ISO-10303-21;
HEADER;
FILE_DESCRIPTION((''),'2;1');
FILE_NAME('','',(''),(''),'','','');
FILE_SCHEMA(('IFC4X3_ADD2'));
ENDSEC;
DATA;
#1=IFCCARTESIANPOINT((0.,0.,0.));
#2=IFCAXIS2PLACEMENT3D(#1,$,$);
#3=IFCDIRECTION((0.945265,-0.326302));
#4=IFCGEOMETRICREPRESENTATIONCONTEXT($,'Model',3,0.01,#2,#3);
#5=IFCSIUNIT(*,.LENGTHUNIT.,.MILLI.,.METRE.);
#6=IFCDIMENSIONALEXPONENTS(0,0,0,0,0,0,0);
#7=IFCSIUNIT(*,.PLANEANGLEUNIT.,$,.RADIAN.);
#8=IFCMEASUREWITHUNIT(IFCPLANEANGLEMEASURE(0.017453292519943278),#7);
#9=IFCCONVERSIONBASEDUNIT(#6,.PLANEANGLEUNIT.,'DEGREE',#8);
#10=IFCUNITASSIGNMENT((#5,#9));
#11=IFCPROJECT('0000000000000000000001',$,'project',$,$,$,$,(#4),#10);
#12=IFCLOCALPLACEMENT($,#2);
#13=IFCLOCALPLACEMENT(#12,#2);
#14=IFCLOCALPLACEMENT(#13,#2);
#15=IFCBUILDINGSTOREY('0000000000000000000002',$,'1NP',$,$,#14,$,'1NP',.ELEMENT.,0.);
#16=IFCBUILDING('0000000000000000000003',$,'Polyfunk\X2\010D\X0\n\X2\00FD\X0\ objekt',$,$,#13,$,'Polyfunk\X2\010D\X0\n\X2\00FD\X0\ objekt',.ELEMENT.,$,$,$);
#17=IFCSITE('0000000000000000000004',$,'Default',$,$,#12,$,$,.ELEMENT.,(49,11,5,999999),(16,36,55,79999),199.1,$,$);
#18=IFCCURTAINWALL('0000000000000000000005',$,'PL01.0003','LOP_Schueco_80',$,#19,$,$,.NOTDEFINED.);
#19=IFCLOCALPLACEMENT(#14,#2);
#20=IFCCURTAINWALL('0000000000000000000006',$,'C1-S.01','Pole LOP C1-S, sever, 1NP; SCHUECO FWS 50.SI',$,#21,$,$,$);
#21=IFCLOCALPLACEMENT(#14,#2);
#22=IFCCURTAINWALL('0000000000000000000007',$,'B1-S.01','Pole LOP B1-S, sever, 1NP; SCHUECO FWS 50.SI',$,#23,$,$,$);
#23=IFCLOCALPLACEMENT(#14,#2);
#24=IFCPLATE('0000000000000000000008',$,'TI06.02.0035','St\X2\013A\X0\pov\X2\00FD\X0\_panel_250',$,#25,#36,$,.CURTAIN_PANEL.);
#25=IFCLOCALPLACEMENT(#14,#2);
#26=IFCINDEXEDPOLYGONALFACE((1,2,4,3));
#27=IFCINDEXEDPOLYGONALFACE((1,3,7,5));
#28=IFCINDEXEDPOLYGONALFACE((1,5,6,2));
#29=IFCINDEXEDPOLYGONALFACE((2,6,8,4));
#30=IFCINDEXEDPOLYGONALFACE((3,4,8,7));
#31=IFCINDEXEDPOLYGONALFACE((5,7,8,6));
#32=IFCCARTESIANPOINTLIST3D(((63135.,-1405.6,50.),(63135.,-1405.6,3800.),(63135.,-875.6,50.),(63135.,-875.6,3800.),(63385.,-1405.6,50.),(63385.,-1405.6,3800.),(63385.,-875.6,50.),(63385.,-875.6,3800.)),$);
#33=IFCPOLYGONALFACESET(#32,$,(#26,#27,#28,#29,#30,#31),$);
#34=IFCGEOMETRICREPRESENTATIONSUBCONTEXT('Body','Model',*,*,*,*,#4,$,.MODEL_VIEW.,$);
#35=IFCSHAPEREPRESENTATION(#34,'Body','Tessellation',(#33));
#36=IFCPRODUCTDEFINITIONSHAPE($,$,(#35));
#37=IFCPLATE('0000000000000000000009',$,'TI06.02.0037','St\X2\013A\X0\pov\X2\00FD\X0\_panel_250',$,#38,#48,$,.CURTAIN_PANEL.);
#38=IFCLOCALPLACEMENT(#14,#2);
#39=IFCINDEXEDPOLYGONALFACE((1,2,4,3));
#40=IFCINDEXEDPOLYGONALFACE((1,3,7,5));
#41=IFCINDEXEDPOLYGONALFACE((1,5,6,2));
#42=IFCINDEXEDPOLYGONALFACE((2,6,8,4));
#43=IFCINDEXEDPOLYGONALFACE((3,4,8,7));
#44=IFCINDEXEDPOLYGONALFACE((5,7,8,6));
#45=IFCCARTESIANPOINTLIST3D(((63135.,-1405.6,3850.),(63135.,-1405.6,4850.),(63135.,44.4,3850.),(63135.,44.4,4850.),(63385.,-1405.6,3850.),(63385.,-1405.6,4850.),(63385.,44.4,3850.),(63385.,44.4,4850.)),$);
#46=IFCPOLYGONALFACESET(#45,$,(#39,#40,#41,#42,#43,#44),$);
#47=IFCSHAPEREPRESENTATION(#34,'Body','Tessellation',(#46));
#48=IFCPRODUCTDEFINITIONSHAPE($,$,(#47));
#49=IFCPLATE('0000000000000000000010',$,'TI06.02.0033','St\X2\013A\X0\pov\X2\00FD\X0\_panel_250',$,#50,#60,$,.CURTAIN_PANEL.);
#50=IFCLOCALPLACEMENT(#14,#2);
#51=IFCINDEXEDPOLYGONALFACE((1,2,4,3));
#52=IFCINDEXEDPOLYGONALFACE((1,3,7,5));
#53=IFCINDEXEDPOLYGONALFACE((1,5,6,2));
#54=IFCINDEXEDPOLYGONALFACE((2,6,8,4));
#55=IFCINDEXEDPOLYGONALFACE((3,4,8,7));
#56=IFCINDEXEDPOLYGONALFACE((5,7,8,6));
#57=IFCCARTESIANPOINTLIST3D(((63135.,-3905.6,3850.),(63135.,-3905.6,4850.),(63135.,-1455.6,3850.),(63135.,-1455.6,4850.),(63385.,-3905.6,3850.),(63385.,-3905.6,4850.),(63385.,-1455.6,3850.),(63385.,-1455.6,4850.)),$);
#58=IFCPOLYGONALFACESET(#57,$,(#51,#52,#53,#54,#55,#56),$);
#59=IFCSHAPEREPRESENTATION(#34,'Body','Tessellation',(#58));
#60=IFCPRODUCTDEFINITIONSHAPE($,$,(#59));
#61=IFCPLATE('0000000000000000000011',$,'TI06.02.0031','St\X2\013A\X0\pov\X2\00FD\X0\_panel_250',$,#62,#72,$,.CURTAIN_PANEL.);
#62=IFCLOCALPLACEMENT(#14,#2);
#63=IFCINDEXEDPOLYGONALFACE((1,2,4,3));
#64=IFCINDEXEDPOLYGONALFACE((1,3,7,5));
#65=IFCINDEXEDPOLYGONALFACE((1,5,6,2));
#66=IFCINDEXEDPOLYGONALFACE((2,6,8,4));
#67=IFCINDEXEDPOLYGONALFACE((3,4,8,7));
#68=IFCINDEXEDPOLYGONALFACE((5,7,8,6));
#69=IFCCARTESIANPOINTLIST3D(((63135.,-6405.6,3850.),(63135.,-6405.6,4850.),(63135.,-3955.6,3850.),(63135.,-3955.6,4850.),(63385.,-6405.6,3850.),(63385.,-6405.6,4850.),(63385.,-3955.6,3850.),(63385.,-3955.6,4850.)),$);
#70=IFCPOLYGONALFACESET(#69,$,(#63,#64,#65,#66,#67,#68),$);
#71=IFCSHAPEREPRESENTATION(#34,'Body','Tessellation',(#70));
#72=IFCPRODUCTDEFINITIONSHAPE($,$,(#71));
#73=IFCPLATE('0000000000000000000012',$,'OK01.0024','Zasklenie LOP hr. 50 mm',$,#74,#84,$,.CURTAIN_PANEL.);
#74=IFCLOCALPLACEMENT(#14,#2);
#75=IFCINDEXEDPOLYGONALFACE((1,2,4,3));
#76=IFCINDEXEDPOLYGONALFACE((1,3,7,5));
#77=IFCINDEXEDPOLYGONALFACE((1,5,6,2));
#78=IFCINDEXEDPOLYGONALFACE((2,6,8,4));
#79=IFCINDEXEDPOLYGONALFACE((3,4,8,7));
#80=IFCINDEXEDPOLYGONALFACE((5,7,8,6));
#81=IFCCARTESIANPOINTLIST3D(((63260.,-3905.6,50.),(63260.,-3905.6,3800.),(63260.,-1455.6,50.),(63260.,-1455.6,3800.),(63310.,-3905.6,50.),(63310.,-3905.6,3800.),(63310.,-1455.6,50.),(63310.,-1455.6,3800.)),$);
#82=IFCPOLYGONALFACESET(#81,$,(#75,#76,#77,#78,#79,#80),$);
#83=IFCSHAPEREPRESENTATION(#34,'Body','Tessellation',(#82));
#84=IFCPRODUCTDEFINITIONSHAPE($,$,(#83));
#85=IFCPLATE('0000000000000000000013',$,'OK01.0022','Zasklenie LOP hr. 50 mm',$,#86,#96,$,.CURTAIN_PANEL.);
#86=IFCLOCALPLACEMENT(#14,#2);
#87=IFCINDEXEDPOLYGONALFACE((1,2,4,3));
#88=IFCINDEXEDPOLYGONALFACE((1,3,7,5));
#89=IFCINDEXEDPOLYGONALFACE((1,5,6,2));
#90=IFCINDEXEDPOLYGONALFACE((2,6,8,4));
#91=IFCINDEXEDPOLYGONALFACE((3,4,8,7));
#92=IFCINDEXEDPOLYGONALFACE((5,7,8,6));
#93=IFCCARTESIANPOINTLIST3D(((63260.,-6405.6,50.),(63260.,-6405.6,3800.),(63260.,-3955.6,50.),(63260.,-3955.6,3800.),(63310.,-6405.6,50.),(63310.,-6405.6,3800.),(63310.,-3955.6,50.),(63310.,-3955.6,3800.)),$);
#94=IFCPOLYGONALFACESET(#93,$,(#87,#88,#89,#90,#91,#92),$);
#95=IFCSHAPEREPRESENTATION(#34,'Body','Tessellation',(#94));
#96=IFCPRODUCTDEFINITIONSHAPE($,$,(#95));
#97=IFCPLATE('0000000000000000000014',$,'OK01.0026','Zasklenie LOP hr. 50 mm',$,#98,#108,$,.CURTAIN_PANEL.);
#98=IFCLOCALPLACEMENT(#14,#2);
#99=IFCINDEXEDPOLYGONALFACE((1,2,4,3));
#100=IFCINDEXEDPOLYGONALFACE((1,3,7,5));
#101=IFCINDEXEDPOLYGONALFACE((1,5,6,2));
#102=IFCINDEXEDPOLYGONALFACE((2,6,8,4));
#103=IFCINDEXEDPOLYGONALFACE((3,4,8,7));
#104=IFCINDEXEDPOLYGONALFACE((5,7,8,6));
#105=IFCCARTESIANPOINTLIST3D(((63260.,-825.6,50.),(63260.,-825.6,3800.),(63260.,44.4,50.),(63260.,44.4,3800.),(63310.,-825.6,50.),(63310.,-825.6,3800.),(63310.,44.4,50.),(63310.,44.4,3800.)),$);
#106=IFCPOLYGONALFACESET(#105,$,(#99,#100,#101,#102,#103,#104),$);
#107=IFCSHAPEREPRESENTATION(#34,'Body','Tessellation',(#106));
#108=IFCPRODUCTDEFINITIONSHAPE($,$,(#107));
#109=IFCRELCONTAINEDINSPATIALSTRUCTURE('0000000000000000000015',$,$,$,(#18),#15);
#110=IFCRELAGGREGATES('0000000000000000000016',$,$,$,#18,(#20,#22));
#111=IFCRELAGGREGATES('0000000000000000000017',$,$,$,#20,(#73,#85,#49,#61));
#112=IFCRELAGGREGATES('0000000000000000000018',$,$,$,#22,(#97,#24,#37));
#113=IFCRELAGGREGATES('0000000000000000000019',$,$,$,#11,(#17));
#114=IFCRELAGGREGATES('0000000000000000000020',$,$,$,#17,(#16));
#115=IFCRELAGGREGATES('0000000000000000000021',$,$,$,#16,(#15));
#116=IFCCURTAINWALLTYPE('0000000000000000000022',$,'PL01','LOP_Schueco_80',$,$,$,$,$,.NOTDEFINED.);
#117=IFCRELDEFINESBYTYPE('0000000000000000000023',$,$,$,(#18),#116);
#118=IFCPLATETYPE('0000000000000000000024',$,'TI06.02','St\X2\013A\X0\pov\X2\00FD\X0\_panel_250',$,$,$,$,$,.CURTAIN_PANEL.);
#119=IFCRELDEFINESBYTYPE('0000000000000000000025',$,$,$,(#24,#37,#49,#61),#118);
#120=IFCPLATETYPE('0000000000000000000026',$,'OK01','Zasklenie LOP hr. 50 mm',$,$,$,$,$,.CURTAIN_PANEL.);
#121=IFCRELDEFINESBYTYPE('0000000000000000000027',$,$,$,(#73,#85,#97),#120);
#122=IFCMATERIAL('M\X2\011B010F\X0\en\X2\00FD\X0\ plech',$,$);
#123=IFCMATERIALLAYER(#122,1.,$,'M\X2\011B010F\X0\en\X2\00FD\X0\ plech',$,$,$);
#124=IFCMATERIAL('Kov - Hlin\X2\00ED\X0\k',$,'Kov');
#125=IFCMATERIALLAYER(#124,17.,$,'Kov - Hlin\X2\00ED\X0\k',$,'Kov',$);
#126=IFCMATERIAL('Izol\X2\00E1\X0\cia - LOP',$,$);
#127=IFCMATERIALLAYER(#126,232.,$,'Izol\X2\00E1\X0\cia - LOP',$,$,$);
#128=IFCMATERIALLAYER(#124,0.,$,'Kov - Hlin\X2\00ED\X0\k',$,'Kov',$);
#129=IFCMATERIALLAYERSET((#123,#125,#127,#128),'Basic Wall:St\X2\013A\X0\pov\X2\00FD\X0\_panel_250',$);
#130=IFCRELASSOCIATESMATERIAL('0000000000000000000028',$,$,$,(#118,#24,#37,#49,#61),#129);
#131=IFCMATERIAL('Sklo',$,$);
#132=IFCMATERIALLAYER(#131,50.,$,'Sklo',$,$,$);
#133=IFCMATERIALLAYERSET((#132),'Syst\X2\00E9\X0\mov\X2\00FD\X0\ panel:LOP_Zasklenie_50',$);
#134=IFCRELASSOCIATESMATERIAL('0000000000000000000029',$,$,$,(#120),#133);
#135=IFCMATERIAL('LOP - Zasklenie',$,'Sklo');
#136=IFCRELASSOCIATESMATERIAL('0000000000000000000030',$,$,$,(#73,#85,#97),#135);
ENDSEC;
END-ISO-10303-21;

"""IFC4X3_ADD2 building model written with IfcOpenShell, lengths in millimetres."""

from ifc_helpers import new_model, entity, si_unit, converted_unit, direction, frame, frame_2d, origin, place, context, subcontext, project, spatial, rectangle, extrude, source, transform, mapped, material, layer, layer_set, layer_usage, type_object, type_shapes, element, aggregate, save


model = new_model("IFC4X3_ADD2")

# Units and contexts
model_context = context("Model", 3, precision=0.01, world=origin(), true_north=direction((0.945265, -0.326302)))
body_context = subcontext(model_context, "Body", "Model", "MODEL_VIEW")
ifc_project = project(units=[si_unit("LENGTHUNIT", "METRE", prefix="MILLI"), converted_unit("PLANEANGLEUNIT", "DEGREE", entity("IfcPlaneAngleMeasure", 0.017453292519943278), si_unit("PLANEANGLEUNIT", "RADIAN"), dimensions=[0, 0, 0, 0, 0, 0, 0])], contexts=[model_context])

# Site, building, storey
site_placement = place(None, origin())
site = spatial("IfcSite", under=ifc_project, at=site_placement, Name="Default", CompositionType="ELEMENT", RefLatitude=(49, 11, 5, 999999), RefLongitude=(16, 36, 55, 79999), RefElevation=199.1)
building_placement = place(site_placement, origin())
building = spatial("IfcBuilding", under=site, at=building_placement, Name="Polyfunkčný objekt", LongName="Polyfunkčný objekt", CompositionType="ELEMENT")
storey_placement = place(building_placement, origin())
storey = spatial("IfcBuildingStorey", under=building, at=storey_placement, Name="1NP", LongName="1NP", CompositionType="ELEMENT", Elevation=0.0)

# Curtain walls, plates
curtain_wall_type = type_object("IfcCurtainWallType", Name="PL01", Description="LOP_Schueco_80", PredefinedType="NOTDEFINED")
curtain_wall_1_placement = place(storey_placement, origin())
curtain_wall_1 = element("IfcCurtainWall", 1, at=curtain_wall_1_placement, inside=storey, type_object=curtain_wall_type, Name="PL01.0003", Description="LOP_Schueco_80", PredefinedType="NOTDEFINED")
curtain_wall_2 = element("IfcCurtainWall", 2, Name="C1-S.01", Description="Pole LOP C1-S, sever, 1NP; SCHUECO FWS 50.SI")
curtain_wall_3 = element("IfcCurtainWall", 3, Name="B1-S.01", Description="Pole LOP B1-S, sever, 1NP; SCHUECO FWS 50.SI")
aggregate(curtain_wall_1, [curtain_wall_2, curtain_wall_3])
ifc_material_1 = material(Name="Měďený plech")
ifc_layer_1 = layer(ifc_material_1, 1.0, Name="Měďený plech")
ifc_material_2 = material(Name="Kov - Hliník", Category="Kov")
ifc_layer_2 = layer(ifc_material_2, 17.0, Name="Kov - Hliník", Category="Kov")
ifc_material_3 = material(Name="Izolácia - LOP")
ifc_layer_3 = layer(ifc_material_3, 232.0, Name="Izolácia - LOP")
ifc_layer_4 = layer(ifc_material_2, 0.0, Name="Kov - Hliník", Category="Kov")
ifc_layer_set_1 = layer_set([ifc_layer_1, ifc_layer_2, ifc_layer_3, ifc_layer_4], Name="Basic Wall:Stĺpový_panel_250")
ifc_layer_usage_1 = layer_usage(ifc_layer_set_1, "AXIS2", "NEGATIVE", 125.0)
plate_type_1 = type_object("IfcPlateType", Name="TI06.02", Description="Stĺpový_panel_250", PredefinedType="CURTAIN_PANEL", material=ifc_layer_set_1)
plate_1_placement = place(storey_placement, frame((63260.0, -875.6, 50.0), z_axis=(0.0, 0.0, 1.0), x_axis=(0.0, -1.0, 0.0)))
plate_1 = element("IfcPlate", 4, at=plate_1_placement, type_object=plate_type_1, material=ifc_layer_usage_1, Name="TI06.02.0035", Description="Stĺpový_panel_250", PredefinedType="CURTAIN_PANEL", context=body_context, shape_type="SweptSolid", body=[
    extrude(rectangle(XDim=250.0, YDim=530.0, at=frame_2d((0.0, 0.0), x_axis=(1.0, 0.0))), frame((265.0, 0.0, 0.0), z_axis=(0.0, 0.0, 1.0), x_axis=(0.0, 1.0, 0.0)), (0.0, 0.0, 1.0), 3750.0),
])
ifc_layer_usage_2 = layer_usage(ifc_layer_set_1, "AXIS2", "NEGATIVE", 125.0)
plate_2_placement = place(storey_placement, frame((63260.0, 44.4, 3850.0), z_axis=(0.0, 0.0, 1.0), x_axis=(0.0, -1.0, 0.0)))
plate_2 = element("IfcPlate", 5, at=plate_2_placement, type_object=plate_type_1, material=ifc_layer_usage_2, Name="TI06.02.0037", Description="Stĺpový_panel_250", PredefinedType="CURTAIN_PANEL", context=body_context, shape_type="SweptSolid", body=[
    extrude(rectangle(XDim=250.0, YDim=1450.0, at=frame_2d((0.0, 0.0), x_axis=(1.0, 0.0))), frame((725.0, 0.0, 0.0), z_axis=(0.0, 0.0, 1.0), x_axis=(0.0, 1.0, 0.0)), (0.0, 0.0, 1.0), 1000.0),
])
ifc_layer_usage_3 = layer_usage(ifc_layer_set_1, "AXIS2", "NEGATIVE", 125.0)
plate_3_placement = place(storey_placement, frame((63260.0, -1455.6, 3850.0), z_axis=(0.0, 0.0, 1.0), x_axis=(0.0, -1.0, 0.0)))
plate_3 = element("IfcPlate", 6, at=plate_3_placement, type_object=plate_type_1, material=ifc_layer_usage_3, Name="TI06.02.0033", Description="Stĺpový_panel_250", PredefinedType="CURTAIN_PANEL", context=body_context, shape_type="SweptSolid", body=[
    extrude(rectangle(XDim=250.0, YDim=2450.0, at=frame_2d((0.0, 0.0), x_axis=(1.0, 0.0))), frame((1225.0, 0.0, 0.0), z_axis=(0.0, 0.0, 1.0), x_axis=(0.0, 1.0, 0.0)), (0.0, 0.0, 1.0), 1000.0),
])
ifc_layer_usage_4 = layer_usage(ifc_layer_set_1, "AXIS2", "NEGATIVE", 125.0)
plate_4_placement = place(storey_placement, frame((63260.0, -3955.6, 3850.0), z_axis=(0.0, 0.0, 1.0), x_axis=(0.0, -1.0, 0.0)))
plate_4 = element("IfcPlate", 7, at=plate_4_placement, type_object=plate_type_1, material=ifc_layer_usage_4, Name="TI06.02.0031", Description="Stĺpový_panel_250", PredefinedType="CURTAIN_PANEL", context=body_context, shape_type="SweptSolid", body=[
    extrude(rectangle(XDim=250.0, YDim=2450.0, at=frame_2d((0.0, 0.0), x_axis=(1.0, 0.0))), frame((1225.0, 0.0, 0.0), z_axis=(0.0, 0.0, 1.0), x_axis=(0.0, 1.0, 0.0)), (0.0, 0.0, 1.0), 1000.0),
])
ifc_material_4 = material(Name="LOP - Zasklenie", Category="Sklo")
ifc_material_5 = material(Name="Sklo")
ifc_layer_5 = layer(ifc_material_5, 50.0, Name="Sklo")
ifc_layer_set_2 = layer_set([ifc_layer_5], Name="Systémový panel:LOP_Zasklenie_50")
plate_type_2 = type_object("IfcPlateType", Name="OK01", Description="Zasklenie LOP hr. 50 mm", PredefinedType="CURTAIN_PANEL", material=ifc_layer_set_2)
shared_shape_1 = source(origin(), body_context, "Body", "SweptSolid", [
    extrude(rectangle(XDim=3750.0, YDim=2450.0, at=frame_2d((-141.7, 0.0), x_axis=(1.0, 0.0))), frame((0.0, 0.0, 2016.7), z_axis=(0.0, 1.0, 0.0), x_axis=(0.0, 0.0, 1.0)), (0.0, 0.0, 1.0), 50.0),
])
plate_5_placement = place(curtain_wall_1_placement, frame((63260.0, -2680.6, 50.0), z_axis=(0.0, 0.0, 1.0), x_axis=(0.0, -1.0, 0.0)))
plate_5 = element("IfcPlate", 8, at=plate_5_placement, type_object=plate_type_2, material=ifc_material_4, Name="OK01.0024", Description="Zasklenie LOP hr. 50 mm", PredefinedType="CURTAIN_PANEL", context=body_context, shape_type="MappedRepresentation", body=[
    mapped(shared_shape_1, transform((0.0, 0.0, 0.0), scale=1.0)),
])
plate_6_placement = place(curtain_wall_1_placement, frame((63260.0, -5180.6, 50.0), z_axis=(0.0, 0.0, 1.0), x_axis=(0.0, -1.0, 0.0)))
plate_6 = element("IfcPlate", 9, at=plate_6_placement, type_object=plate_type_2, material=ifc_material_4, Name="OK01.0022", Description="Zasklenie LOP hr. 50 mm", PredefinedType="CURTAIN_PANEL", context=body_context, shape_type="MappedRepresentation", body=[
    mapped(shared_shape_1, transform((0.0, 0.0, 0.0), scale=1.0)),
])
aggregate(curtain_wall_2, [plate_5, plate_6, plate_3, plate_4])
shared_shape_2 = source(origin(), body_context, "Body", "SweptSolid", [
    extrude(rectangle(XDim=3750.0, YDim=870.0, at=frame_2d((-141.7, 0.0), x_axis=(1.0, 0.0))), frame((0.0, 0.0, 2016.7), z_axis=(0.0, 1.0, 0.0), x_axis=(0.0, 0.0, 1.0)), (0.0, 0.0, 1.0), 50.0),
])
type_shapes(plate_type_2, [shared_shape_1, shared_shape_2])
plate_7_placement = place(curtain_wall_1_placement, frame((63260.0, -390.6, 50.0), z_axis=(0.0, 0.0, 1.0), x_axis=(0.0, -1.0, 0.0)))
plate_7 = element("IfcPlate", 10, at=plate_7_placement, type_object=plate_type_2, material=ifc_material_4, Name="OK01.0026", Description="Zasklenie LOP hr. 50 mm", PredefinedType="CURTAIN_PANEL", context=body_context, shape_type="MappedRepresentation", body=[
    mapped(shared_shape_2, transform((0.0, 0.0, 0.0), scale=1.0)),
])
aggregate(curtain_wall_3, [plate_7, plate_1, plate_2])

save(model, "model.ifc")
